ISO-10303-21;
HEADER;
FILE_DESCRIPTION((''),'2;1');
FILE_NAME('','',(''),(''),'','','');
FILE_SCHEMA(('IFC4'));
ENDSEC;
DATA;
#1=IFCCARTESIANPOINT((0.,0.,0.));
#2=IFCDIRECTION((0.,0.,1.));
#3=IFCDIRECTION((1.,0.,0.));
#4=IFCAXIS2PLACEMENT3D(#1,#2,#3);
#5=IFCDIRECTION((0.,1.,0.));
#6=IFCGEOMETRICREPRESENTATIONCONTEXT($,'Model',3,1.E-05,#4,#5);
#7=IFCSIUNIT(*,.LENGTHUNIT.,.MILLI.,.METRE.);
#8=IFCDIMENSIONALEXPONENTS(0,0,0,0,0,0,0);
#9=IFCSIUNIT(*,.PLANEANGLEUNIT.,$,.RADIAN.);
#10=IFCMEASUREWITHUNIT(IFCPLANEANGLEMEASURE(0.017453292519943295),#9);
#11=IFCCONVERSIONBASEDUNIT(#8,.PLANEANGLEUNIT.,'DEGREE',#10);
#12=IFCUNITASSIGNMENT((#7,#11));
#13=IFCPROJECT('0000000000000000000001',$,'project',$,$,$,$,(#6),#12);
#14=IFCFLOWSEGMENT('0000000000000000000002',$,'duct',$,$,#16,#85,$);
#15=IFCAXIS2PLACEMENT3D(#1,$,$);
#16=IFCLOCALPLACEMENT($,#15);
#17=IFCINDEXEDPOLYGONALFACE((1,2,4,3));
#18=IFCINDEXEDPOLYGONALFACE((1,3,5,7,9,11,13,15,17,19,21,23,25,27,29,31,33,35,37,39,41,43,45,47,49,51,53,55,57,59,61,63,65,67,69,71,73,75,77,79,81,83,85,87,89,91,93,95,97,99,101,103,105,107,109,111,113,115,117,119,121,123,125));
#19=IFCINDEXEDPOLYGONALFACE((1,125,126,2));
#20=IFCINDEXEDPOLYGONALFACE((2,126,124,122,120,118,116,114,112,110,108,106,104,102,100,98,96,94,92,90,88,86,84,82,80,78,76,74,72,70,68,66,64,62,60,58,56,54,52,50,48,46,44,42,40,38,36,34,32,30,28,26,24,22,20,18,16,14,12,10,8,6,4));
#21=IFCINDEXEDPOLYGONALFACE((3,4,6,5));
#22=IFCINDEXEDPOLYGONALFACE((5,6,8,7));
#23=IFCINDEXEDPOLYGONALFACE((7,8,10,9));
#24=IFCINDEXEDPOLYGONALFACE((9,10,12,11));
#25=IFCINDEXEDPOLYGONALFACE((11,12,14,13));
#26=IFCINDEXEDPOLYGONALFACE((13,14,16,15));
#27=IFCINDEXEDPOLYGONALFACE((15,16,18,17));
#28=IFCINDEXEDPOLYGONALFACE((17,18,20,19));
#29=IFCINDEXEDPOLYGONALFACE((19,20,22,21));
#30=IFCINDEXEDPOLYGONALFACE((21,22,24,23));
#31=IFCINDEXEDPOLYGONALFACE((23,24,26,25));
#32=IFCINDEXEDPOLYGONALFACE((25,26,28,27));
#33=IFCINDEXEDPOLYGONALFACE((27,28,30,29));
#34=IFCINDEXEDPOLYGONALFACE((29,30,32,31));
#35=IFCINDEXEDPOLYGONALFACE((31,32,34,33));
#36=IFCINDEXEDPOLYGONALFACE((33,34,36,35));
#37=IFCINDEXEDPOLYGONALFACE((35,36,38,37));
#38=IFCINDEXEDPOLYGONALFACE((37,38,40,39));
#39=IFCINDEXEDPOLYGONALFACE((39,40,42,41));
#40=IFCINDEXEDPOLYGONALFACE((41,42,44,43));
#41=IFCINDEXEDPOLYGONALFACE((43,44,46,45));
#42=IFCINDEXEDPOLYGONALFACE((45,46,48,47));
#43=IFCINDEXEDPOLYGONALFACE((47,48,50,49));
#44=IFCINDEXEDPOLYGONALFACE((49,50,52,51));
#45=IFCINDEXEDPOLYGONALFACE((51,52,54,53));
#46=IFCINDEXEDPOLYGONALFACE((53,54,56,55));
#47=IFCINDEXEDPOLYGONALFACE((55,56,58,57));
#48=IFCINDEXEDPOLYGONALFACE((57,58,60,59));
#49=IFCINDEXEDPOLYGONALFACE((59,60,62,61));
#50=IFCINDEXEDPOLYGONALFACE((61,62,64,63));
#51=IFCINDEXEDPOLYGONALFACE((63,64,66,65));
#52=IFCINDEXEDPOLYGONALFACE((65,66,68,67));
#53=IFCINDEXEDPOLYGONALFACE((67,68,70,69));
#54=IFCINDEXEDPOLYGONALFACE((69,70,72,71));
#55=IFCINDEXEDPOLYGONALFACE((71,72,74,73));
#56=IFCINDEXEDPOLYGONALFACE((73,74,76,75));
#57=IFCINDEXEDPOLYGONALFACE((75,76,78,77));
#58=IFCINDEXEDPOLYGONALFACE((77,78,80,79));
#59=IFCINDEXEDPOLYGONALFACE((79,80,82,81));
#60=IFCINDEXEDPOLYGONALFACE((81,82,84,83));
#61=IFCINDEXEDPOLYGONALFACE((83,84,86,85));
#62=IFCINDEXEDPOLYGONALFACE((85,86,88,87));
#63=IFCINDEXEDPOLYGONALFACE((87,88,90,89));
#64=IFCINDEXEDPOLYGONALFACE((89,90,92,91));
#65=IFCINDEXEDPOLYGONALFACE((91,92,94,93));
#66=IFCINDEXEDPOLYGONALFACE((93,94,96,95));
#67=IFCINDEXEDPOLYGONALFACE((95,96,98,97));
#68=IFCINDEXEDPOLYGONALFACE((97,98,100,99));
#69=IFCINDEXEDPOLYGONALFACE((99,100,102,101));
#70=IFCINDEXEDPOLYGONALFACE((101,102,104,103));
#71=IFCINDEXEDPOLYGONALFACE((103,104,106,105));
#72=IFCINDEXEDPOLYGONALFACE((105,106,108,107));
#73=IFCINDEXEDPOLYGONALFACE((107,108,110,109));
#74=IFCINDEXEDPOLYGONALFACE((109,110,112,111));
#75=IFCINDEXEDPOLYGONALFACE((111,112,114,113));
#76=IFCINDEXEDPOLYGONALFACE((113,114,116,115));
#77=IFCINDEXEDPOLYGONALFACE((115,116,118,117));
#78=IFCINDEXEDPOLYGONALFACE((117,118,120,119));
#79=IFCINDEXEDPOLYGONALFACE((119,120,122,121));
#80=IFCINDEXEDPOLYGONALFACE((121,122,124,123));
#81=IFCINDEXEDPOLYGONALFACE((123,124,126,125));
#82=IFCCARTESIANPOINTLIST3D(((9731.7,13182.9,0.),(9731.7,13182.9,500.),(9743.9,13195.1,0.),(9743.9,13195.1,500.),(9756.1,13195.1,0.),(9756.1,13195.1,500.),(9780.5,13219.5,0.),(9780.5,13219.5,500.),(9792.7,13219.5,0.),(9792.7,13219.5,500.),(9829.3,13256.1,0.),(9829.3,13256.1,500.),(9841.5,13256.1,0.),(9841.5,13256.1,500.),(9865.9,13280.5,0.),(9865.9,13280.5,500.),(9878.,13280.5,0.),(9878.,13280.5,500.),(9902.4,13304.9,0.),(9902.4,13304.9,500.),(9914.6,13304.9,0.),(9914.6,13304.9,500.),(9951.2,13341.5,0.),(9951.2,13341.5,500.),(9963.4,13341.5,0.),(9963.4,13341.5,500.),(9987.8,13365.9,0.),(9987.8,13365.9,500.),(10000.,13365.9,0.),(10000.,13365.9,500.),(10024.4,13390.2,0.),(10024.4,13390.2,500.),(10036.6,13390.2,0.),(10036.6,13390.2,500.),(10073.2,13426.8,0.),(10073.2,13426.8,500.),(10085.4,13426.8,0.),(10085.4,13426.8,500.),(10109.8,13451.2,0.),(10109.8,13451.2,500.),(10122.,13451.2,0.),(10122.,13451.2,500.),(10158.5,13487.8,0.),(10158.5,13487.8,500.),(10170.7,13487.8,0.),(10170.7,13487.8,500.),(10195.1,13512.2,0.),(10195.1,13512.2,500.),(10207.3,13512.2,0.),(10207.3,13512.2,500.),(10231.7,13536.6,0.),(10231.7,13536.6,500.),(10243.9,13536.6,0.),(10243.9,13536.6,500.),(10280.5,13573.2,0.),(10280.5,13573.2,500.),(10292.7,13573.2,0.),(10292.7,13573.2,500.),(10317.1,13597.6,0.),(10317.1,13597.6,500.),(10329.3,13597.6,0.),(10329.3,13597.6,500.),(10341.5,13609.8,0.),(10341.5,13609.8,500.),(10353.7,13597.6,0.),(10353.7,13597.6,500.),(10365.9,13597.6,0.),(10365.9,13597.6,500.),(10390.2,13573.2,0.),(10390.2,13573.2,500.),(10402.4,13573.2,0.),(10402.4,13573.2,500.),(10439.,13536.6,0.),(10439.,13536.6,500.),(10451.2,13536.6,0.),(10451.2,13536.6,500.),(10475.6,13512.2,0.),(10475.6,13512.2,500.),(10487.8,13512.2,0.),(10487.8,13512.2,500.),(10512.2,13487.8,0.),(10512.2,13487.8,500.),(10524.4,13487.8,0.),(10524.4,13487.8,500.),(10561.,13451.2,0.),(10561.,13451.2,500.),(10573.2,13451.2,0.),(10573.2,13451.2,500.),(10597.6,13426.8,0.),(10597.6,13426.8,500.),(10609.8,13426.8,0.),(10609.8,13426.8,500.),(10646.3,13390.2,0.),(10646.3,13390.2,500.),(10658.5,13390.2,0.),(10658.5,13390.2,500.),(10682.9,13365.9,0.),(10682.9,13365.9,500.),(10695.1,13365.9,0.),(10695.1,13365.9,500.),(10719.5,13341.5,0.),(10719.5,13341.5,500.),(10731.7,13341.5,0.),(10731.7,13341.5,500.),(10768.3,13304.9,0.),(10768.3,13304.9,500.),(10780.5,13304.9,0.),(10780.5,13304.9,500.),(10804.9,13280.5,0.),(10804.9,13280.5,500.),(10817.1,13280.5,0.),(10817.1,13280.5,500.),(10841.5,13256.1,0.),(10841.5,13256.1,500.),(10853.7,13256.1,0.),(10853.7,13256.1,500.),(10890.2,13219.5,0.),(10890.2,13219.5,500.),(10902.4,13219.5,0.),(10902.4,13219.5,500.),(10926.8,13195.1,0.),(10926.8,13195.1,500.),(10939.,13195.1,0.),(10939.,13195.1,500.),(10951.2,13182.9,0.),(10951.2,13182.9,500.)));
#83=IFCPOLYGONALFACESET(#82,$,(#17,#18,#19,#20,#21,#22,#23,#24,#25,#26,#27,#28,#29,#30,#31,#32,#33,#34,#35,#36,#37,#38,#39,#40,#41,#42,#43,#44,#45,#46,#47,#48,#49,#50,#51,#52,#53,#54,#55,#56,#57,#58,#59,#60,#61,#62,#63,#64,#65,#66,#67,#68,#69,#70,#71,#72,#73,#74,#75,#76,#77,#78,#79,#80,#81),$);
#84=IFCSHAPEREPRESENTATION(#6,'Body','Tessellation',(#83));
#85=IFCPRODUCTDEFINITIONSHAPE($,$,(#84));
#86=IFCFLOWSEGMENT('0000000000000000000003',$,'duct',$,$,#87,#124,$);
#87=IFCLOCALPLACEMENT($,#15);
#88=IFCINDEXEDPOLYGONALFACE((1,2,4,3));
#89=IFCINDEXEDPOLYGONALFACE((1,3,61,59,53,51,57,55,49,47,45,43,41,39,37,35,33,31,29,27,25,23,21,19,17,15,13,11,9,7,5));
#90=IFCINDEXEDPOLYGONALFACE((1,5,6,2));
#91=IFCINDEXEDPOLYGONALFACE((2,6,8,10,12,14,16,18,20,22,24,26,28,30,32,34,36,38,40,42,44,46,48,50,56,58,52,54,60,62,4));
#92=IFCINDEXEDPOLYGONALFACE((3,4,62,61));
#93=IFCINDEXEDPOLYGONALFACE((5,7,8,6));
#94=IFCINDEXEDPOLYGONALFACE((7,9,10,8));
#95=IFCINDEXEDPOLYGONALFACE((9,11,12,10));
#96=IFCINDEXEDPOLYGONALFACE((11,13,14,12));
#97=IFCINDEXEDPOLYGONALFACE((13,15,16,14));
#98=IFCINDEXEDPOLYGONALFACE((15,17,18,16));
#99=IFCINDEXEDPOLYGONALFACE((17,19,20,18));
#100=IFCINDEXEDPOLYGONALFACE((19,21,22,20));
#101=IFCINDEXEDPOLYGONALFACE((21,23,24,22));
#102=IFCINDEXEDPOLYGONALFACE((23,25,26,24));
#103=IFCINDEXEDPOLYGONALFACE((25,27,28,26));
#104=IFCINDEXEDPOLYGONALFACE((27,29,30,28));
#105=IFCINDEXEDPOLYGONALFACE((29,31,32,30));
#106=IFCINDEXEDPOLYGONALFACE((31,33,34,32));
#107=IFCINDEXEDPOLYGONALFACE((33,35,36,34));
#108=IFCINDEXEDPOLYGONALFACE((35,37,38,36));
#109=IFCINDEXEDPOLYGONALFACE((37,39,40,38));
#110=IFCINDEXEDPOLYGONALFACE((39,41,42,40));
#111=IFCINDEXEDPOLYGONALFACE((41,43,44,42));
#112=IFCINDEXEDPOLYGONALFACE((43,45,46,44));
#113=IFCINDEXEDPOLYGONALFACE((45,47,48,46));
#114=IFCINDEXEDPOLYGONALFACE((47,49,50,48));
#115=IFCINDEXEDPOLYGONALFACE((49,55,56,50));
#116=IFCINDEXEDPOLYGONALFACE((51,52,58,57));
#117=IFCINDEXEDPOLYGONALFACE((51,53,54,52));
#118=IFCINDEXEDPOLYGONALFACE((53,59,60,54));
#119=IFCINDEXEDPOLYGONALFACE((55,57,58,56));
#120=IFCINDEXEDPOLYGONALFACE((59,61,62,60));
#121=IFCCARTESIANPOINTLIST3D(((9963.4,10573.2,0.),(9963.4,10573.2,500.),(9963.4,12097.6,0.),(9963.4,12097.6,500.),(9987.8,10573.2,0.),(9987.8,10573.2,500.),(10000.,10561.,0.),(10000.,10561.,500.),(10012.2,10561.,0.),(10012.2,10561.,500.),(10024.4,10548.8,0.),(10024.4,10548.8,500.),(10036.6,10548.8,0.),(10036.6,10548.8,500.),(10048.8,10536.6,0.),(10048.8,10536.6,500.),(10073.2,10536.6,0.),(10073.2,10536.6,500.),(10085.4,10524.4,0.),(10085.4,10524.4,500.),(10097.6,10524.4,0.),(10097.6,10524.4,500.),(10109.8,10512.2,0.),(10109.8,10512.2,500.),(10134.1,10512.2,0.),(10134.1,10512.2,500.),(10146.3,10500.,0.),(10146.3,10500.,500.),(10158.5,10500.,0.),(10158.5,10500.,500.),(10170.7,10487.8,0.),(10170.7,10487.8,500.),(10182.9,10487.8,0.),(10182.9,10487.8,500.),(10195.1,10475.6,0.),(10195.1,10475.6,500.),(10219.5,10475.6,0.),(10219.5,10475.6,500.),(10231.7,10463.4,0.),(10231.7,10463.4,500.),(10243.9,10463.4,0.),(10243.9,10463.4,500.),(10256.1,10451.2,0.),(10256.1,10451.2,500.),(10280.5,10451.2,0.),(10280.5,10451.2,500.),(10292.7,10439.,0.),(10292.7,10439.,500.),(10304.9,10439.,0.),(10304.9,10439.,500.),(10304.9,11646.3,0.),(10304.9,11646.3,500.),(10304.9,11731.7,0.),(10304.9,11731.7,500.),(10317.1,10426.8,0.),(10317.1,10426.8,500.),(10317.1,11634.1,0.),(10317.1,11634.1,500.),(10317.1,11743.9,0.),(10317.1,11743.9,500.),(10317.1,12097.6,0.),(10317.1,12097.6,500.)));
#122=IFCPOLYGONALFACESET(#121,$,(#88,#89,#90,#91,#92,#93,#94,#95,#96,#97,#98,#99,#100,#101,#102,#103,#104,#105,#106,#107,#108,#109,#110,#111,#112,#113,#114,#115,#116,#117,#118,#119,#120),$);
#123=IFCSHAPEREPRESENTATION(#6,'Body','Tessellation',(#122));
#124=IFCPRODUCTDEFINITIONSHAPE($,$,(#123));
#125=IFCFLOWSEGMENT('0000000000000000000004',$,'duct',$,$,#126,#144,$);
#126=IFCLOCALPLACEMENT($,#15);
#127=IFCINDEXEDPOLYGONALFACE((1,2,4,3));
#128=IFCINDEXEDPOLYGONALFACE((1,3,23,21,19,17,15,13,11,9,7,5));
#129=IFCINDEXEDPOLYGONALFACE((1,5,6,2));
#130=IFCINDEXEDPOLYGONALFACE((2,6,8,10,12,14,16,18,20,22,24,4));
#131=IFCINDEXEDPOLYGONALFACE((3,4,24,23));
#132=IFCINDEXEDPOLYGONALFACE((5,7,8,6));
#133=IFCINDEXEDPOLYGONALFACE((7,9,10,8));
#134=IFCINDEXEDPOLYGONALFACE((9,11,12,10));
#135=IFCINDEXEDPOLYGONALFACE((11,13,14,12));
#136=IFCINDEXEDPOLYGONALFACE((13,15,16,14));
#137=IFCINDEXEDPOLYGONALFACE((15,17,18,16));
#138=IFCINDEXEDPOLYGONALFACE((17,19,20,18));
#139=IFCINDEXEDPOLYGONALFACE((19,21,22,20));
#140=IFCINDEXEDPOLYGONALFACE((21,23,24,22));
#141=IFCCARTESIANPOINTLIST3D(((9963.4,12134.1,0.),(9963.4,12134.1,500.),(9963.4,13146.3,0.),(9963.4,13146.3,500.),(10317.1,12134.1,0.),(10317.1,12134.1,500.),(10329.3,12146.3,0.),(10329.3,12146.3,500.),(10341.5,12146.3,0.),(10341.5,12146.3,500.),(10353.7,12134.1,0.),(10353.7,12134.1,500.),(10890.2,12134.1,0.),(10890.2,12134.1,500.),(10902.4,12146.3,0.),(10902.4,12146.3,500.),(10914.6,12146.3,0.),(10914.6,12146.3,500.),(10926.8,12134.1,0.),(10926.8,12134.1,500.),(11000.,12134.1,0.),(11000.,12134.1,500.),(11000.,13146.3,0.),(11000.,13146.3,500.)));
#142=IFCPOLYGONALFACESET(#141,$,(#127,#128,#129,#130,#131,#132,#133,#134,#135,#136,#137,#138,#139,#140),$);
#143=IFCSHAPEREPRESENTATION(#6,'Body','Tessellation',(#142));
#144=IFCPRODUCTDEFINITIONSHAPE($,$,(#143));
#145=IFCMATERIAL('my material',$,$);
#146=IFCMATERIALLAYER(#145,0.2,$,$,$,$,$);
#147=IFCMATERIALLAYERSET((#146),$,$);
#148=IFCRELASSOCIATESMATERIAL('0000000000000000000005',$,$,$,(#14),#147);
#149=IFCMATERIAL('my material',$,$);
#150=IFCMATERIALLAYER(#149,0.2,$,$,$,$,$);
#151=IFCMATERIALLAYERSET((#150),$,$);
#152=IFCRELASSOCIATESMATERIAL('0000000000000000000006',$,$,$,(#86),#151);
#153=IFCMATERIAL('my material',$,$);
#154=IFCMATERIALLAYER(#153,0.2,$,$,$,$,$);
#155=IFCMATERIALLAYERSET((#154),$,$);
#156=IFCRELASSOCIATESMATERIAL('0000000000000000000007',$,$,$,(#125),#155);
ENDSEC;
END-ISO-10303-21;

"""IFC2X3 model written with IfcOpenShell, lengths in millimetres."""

from ifc_helpers import new_model, entity, si_unit, converted_unit, direction, origin_with_axes, place, context, project, polyline, outline, extrude, material, layer, layer_set, layer_usage, element, save


model = new_model("IFC2X3")

# Units and contexts
model_context = context("Model", 3, precision=1e-05, world=origin_with_axes(), true_north=direction((0.0, 1.0, 0.0)))
ifc_project = project(units=[si_unit("LENGTHUNIT", "METRE", prefix="MILLI"), converted_unit("PLANEANGLEUNIT", "DEGREE", entity("IfcPlaneAngleMeasure", 0.017453292519943295), si_unit("PLANEANGLEUNIT", "RADIAN"), dimensions=[0, 0, 0, 0, 0, 0, 0])], contexts=[model_context])

# Flow segments
ifc_material_1 = material(Name="my material")
ifc_layer_1 = layer(ifc_material_1, 0.2)
ifc_layer_set_1 = layer_set([ifc_layer_1])
ifc_layer_usage_1 = layer_usage(ifc_layer_set_1, "AXIS2", "POSITIVE", -0.1)
flow_segment_1_placement = place(None, origin_with_axes())
element("IfcFlowSegment", 1, at=flow_segment_1_placement, material=ifc_layer_usage_1, Name="duct", context=model_context, shape_type="SweptSolid", body=[
    extrude(outline(polyline([(9731.7, 13182.9), (10951.2, 13182.9), (10939.0, 13195.1), (10926.8, 13195.1), (10902.4, 13219.5), (10890.2, 13219.5), (10853.7, 13256.1), (10841.5, 13256.1), (10817.1, 13280.5), (10804.9, 13280.5), (10780.5, 13304.9), (10768.3, 13304.9), (10731.7, 13341.5), (10719.5, 13341.5), (10695.1, 13365.9), (10682.9, 13365.9), (10658.5, 13390.2), (10646.3, 13390.2), (10609.8, 13426.8), (10597.6, 13426.8), (10573.2, 13451.2), (10561.0, 13451.2), (10524.4, 13487.8), (10512.2, 13487.8), (10487.8, 13512.2), (10475.6, 13512.2), (10451.2, 13536.6), (10439.0, 13536.6), (10402.4, 13573.2), (10390.2, 13573.2), (10365.9, 13597.6), (10353.7, 13597.6), (10341.5, 13609.8), (10329.3, 13597.6), (10317.1, 13597.6), (10292.7, 13573.2), (10280.5, 13573.2), (10243.9, 13536.6), (10231.7, 13536.6), (10207.3, 13512.2), (10195.1, 13512.2), (10170.7, 13487.8), (10158.5, 13487.8), (10122.0, 13451.2), (10109.8, 13451.2), (10085.4, 13426.8), (10073.2, 13426.8), (10036.6, 13390.2), (10024.4, 13390.2), (10000.0, 13365.9), (9987.8, 13365.9), (9963.4, 13341.5), (9951.2, 13341.5), (9914.6, 13304.9), (9902.4, 13304.9), (9878.0, 13280.5), (9865.9, 13280.5), (9841.5, 13256.1), (9829.3, 13256.1), (9792.7, 13219.5), (9780.5, 13219.5), (9756.1, 13195.1), (9743.9, 13195.1), (9731.7, 13182.9)])), origin_with_axes(), (0.0, 0.0, 1.0), 500.0),
])
ifc_material_2 = material(Name="my material")
ifc_layer_2 = layer(ifc_material_2, 0.2)
ifc_layer_set_2 = layer_set([ifc_layer_2])
ifc_layer_usage_2 = layer_usage(ifc_layer_set_2, "AXIS2", "POSITIVE", -0.1)
flow_segment_2_placement = place(None, origin_with_axes())
element("IfcFlowSegment", 2, at=flow_segment_2_placement, material=ifc_layer_usage_2, Name="duct", context=model_context, shape_type="SweptSolid", body=[
    extrude(outline(polyline([(9963.4, 10573.2), (9987.8, 10573.2), (10000.0, 10561.0), (10012.2, 10561.0), (10024.4, 10548.8), (10036.6, 10548.8), (10048.8, 10536.6), (10073.2, 10536.6), (10085.4, 10524.4), (10097.6, 10524.4), (10109.8, 10512.2), (10134.1, 10512.2), (10146.3, 10500.0), (10158.5, 10500.0), (10170.7, 10487.8), (10182.9, 10487.8), (10195.1, 10475.6), (10219.5, 10475.6), (10231.7, 10463.4), (10243.9, 10463.4), (10256.1, 10451.2), (10280.5, 10451.2), (10292.7, 10439.0), (10304.9, 10439.0), (10317.1, 10426.8), (10317.1, 11634.1), (10304.9, 11646.3), (10304.9, 11731.7), (10317.1, 11743.9), (10317.1, 12097.6), (9963.4, 12097.6), (9963.4, 10573.2)])), origin_with_axes(), (0.0, 0.0, 1.0), 500.0),
])
ifc_material_3 = material(Name="my material")
ifc_layer_3 = layer(ifc_material_3, 0.2)
ifc_layer_set_3 = layer_set([ifc_layer_3])
ifc_layer_usage_3 = layer_usage(ifc_layer_set_3, "AXIS2", "POSITIVE", -0.1)
flow_segment_3_placement = place(None, origin_with_axes())
element("IfcFlowSegment", 3, at=flow_segment_3_placement, material=ifc_layer_usage_3, Name="duct", context=model_context, shape_type="SweptSolid", body=[
    extrude(outline(polyline([(9963.4, 12134.1), (10317.1, 12134.1), (10329.3, 12146.3), (10341.5, 12146.3), (10353.7, 12134.1), (10890.2, 12134.1), (10902.4, 12146.3), (10914.6, 12146.3), (10926.8, 12134.1), (11000.0, 12134.1), (11000.0, 13146.3), (9963.4, 13146.3), (9963.4, 12134.1)])), origin_with_axes(), (0.0, 0.0, 1.0), 500.0),
])

save(model, "model.ifc")
